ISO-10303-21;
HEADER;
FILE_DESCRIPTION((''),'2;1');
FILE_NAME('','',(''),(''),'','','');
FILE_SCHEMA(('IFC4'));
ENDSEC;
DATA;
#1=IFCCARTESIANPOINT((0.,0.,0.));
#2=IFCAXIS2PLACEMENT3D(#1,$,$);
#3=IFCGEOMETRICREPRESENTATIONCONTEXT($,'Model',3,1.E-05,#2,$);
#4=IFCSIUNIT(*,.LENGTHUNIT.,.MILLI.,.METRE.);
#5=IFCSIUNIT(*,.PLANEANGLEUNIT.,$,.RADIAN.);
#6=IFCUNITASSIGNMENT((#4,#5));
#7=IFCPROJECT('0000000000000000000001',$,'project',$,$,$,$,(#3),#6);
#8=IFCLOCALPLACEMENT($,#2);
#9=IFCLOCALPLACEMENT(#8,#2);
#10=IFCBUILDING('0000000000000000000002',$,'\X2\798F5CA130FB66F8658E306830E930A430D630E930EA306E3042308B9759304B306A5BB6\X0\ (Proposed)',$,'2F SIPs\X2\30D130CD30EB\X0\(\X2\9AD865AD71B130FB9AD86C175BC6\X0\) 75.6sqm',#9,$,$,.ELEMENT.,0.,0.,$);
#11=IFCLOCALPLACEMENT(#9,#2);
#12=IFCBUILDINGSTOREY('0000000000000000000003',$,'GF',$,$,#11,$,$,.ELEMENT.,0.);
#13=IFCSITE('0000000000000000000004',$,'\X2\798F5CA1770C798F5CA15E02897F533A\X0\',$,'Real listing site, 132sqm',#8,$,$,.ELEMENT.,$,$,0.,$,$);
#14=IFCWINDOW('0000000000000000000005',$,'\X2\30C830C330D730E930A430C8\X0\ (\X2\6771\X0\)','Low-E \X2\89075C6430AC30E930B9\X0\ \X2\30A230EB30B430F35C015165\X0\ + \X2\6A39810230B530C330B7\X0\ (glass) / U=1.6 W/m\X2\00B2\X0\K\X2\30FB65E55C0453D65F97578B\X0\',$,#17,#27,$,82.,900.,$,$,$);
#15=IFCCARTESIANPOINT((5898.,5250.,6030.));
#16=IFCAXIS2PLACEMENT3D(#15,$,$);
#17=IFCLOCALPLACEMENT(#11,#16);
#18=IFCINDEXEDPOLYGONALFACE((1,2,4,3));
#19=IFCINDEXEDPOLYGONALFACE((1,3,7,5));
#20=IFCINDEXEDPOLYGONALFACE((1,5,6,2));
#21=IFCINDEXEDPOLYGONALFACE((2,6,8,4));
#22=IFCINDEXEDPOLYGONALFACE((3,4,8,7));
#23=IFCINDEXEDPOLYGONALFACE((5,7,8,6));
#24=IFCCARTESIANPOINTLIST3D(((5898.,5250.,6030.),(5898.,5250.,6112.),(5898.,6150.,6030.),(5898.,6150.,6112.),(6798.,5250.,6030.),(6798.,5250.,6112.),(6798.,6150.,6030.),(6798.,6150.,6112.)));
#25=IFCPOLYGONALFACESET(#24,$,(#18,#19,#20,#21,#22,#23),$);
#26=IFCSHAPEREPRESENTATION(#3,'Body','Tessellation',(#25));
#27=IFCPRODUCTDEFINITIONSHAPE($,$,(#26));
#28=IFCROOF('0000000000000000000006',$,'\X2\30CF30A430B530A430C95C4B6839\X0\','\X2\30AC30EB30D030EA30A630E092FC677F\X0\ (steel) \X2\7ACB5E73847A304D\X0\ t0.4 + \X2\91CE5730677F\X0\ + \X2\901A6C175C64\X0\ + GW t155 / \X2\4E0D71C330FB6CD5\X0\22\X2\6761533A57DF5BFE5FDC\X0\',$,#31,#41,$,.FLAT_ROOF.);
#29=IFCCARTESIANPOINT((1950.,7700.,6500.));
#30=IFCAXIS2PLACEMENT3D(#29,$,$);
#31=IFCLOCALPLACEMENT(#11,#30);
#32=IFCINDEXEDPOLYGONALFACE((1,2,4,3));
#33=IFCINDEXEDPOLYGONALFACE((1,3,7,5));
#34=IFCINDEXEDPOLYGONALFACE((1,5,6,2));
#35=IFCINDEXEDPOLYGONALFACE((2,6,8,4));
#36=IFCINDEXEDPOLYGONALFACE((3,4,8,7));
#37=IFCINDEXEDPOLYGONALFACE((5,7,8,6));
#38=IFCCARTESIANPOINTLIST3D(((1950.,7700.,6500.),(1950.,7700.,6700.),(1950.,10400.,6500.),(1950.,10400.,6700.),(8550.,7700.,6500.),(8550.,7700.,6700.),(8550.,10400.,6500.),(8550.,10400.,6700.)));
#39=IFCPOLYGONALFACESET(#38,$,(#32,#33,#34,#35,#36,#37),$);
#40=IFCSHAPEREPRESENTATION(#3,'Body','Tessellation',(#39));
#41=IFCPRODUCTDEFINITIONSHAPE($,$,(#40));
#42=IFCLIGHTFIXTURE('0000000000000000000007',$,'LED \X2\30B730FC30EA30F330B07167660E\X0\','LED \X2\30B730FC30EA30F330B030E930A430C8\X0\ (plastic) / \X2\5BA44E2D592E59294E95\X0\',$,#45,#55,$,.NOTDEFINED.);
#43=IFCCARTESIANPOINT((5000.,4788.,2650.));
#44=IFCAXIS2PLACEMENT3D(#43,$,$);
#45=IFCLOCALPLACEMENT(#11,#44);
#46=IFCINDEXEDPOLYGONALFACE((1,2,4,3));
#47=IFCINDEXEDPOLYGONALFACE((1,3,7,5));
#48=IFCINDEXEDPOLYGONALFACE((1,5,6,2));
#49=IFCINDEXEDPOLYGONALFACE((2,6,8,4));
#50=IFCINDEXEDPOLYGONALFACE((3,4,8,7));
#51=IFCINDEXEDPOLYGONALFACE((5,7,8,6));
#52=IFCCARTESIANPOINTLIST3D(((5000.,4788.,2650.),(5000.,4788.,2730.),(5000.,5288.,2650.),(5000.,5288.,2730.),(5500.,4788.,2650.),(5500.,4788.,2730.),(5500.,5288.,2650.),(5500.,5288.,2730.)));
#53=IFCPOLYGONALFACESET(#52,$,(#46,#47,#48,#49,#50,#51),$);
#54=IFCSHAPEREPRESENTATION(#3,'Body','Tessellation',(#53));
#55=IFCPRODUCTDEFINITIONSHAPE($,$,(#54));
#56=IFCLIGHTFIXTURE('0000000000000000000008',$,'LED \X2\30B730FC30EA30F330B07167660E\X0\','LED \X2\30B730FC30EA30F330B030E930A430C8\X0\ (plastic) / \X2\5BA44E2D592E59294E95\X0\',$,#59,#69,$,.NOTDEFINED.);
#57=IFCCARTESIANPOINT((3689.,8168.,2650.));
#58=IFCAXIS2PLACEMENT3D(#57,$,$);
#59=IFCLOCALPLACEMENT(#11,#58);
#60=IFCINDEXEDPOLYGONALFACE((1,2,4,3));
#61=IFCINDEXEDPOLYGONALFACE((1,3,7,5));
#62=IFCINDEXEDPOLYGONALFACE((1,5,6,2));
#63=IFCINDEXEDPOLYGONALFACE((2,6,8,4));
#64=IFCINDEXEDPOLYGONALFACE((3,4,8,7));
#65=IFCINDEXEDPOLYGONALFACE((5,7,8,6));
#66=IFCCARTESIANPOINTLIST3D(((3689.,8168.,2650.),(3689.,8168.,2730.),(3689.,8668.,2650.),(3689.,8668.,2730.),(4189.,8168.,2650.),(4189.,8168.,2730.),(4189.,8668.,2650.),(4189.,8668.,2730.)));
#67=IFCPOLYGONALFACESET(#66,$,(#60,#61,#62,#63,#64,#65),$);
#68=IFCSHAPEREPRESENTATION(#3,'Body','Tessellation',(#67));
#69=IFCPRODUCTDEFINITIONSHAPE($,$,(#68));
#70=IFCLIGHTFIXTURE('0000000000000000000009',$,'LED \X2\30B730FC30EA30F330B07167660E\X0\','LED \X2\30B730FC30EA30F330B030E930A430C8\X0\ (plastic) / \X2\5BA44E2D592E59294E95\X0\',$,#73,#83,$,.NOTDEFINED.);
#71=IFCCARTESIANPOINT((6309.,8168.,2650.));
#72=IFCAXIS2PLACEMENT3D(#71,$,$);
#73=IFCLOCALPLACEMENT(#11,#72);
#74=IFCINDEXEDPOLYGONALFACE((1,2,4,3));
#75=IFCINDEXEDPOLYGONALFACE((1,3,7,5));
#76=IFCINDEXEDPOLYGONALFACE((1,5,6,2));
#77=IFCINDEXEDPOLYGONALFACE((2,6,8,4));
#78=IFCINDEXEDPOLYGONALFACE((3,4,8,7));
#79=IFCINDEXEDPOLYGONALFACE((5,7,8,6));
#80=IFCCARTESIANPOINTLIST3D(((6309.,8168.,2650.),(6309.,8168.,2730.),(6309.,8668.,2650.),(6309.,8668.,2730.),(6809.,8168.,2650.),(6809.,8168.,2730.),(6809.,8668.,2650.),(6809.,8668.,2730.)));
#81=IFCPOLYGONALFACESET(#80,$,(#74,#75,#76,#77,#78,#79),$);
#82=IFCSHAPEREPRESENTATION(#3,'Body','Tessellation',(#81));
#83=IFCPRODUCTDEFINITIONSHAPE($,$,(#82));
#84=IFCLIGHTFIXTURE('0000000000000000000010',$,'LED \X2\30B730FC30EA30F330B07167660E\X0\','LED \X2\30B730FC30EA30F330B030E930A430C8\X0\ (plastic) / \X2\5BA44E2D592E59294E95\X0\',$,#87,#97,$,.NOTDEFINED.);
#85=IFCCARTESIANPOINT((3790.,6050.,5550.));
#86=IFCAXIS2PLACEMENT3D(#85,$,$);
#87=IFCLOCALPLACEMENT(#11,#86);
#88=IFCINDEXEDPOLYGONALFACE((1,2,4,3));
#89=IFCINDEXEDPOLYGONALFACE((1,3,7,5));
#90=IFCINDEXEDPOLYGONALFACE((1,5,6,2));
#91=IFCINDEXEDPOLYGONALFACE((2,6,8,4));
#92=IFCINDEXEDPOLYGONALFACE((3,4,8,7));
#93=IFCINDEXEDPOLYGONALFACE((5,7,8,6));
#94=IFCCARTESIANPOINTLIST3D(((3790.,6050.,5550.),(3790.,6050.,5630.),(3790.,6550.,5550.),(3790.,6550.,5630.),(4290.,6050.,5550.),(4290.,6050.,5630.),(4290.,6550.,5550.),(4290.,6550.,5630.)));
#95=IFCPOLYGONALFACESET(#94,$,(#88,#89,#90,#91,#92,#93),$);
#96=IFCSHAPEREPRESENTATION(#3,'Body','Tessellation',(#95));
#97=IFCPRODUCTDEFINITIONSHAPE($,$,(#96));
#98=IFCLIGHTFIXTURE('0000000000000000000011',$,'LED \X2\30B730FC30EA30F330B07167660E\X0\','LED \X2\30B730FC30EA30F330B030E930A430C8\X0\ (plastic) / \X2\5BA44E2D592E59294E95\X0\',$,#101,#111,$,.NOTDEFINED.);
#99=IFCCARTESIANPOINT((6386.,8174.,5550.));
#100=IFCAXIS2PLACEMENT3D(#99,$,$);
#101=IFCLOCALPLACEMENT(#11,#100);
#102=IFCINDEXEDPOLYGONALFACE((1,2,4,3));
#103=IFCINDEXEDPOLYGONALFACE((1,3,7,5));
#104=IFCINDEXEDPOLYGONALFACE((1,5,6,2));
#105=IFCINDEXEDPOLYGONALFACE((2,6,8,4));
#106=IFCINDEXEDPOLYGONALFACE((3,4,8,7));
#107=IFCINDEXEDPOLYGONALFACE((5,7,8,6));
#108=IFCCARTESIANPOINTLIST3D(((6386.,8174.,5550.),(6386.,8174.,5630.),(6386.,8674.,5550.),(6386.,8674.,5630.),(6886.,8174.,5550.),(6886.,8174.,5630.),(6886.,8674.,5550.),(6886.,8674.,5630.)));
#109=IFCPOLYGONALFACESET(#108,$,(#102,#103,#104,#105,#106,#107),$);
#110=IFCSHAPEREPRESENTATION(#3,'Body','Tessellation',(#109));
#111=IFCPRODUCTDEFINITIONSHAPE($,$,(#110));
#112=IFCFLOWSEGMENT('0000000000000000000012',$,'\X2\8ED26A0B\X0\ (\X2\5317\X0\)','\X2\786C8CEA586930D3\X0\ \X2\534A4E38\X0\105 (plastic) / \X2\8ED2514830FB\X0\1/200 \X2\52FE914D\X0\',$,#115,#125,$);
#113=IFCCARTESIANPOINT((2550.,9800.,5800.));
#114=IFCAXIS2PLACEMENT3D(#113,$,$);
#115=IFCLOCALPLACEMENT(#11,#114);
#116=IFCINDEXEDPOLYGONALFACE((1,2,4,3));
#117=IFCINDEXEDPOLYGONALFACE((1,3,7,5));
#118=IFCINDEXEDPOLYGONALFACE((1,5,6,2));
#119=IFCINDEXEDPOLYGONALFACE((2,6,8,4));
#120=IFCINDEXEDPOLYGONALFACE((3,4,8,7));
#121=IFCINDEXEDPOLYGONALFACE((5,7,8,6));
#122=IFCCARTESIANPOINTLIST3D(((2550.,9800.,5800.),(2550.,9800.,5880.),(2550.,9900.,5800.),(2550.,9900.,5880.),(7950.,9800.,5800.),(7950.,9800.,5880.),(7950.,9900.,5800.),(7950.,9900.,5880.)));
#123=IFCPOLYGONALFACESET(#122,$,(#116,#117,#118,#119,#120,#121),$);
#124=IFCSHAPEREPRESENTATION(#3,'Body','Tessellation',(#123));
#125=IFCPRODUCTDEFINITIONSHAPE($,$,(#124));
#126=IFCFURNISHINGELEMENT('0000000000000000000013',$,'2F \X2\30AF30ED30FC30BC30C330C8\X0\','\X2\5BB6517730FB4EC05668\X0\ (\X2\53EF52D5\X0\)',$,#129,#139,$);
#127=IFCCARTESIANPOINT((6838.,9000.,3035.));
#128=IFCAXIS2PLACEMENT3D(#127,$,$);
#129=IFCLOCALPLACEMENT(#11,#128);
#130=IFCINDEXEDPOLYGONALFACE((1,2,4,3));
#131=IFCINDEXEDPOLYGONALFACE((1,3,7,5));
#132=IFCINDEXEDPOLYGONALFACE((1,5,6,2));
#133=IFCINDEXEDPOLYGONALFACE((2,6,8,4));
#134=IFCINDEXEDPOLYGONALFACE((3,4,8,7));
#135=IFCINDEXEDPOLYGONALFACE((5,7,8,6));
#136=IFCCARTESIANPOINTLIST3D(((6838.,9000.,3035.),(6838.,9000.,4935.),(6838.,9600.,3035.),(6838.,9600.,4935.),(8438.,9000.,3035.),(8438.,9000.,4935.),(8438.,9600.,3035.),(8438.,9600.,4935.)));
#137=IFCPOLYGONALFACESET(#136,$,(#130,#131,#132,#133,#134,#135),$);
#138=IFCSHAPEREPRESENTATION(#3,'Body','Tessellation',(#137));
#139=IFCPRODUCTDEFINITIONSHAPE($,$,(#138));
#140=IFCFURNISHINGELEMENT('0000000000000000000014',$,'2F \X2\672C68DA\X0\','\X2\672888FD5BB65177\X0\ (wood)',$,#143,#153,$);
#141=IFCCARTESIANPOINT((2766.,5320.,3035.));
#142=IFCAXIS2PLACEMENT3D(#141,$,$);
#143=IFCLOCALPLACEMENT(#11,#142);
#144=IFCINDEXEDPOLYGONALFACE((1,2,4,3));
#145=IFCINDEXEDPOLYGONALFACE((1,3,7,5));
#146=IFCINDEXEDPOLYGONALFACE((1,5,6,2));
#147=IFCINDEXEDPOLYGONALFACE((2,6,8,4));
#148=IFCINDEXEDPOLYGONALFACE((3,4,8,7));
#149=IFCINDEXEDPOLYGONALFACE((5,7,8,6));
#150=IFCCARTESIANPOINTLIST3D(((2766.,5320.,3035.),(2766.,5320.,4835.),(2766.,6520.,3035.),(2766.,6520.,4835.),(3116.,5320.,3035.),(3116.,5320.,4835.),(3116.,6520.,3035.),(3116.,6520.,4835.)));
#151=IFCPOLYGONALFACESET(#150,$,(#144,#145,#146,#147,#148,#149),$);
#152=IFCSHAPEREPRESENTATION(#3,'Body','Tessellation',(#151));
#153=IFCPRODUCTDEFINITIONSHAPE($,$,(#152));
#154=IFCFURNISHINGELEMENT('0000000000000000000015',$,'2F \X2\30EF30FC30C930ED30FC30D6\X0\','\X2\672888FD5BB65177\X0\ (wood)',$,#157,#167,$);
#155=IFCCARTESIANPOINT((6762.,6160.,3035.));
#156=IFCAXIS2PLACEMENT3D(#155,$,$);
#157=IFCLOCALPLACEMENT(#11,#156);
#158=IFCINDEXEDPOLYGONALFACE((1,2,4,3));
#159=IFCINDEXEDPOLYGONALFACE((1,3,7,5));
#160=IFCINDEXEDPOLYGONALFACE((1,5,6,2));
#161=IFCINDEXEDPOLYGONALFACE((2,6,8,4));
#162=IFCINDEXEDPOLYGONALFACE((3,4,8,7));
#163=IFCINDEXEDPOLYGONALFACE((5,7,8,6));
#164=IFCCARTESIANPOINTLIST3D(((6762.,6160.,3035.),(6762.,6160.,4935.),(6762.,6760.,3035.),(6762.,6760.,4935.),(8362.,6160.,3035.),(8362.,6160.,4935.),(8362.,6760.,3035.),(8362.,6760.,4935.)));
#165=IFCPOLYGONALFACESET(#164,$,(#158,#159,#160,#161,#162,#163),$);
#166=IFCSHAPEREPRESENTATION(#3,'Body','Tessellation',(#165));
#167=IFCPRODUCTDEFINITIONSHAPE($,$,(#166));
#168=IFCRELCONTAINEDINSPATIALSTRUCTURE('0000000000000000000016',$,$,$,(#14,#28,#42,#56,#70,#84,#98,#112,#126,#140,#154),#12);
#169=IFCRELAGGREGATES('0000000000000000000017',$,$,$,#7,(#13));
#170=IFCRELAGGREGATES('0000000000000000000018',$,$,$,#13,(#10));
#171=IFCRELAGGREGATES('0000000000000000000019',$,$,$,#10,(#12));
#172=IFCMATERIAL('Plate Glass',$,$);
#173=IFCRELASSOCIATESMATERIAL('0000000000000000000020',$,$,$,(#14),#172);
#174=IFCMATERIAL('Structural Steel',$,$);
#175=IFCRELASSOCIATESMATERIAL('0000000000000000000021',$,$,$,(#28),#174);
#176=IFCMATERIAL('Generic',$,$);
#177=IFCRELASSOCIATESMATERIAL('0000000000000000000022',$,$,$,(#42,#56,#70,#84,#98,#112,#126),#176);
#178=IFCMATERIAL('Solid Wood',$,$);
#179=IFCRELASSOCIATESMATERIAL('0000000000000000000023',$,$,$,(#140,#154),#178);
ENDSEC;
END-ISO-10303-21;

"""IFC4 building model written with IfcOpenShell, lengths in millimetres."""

from ifc_helpers import new_model, si_unit, frame, frame_2d, origin, place, context, project, spatial, rectangle, extrude, material, element, save


model = new_model("IFC4")

# Units and contexts
model_context = context("Model", 3, precision=1e-05, world=origin())
ifc_project = project(units=[si_unit("LENGTHUNIT", "METRE", prefix="MILLI"), si_unit("PLANEANGLEUNIT", "RADIAN")], contexts=[model_context])

# Site, building, storey
site_placement = place(None, origin())
site = spatial("IfcSite", under=ifc_project, at=site_placement, Name="福岡県福岡市西区", ObjectType="Real listing site, 132sqm", CompositionType="ELEMENT", RefElevation=0.0)
building_placement = place(site_placement, origin())
building = spatial("IfcBuilding", under=site, at=building_placement, Name="福岡・書斎とライブラリのある静かな家 (Proposed)", ObjectType="2F SIPsパネル(高断熱・高気密) 75.6sqm", CompositionType="ELEMENT", ElevationOfRefHeight=0.0, ElevationOfTerrain=0.0)
storey_placement = place(building_placement, origin())
storey = spatial("IfcBuildingStorey", under=building, at=storey_placement, Name="GF", CompositionType="ELEMENT", Elevation=0.0)

# Shared definitions
ifc_material_1 = material(Name="Solid Wood")

# Shared definitions
ifc_material_2 = material(Name="Plate Glass")

# Window
window_1_placement = place(storey_placement, frame((5898.0, 5250.0, 6030.0)))
element("IfcWindow", 1, at=window_1_placement, inside=storey, material=ifc_material_2, Name="トップライト (東)", Description="Low-E 複層ガラス アルゴン封入 + 樹脂サッシ (glass) / U=1.6 W/m²K・日射取得型", OverallHeight=82.0, OverallWidth=900.0, context=model_context, shape_type="SweptSolid", body=[
    extrude(rectangle(XDim=900.0, YDim=900.0, at=frame_2d((450.0, 450.0))), frame((5898.0, 5250.0, 6030.0)), (0.0, 0.0, 1.0), 82.0),
])

# Roof
ifc_material_3 = material(Name="Structural Steel")
roof_placement = place(storey_placement, frame((1950.0, 7700.0, 6500.0)))
element("IfcRoof", 2, at=roof_placement, inside=storey, material=ifc_material_3, Name="ハイサイド屋根", Description="ガルバリウム鋼板 (steel) 立平葺き t0.4 + 野地板 + 通気層 + GW t155 / 不燃・法22条区域対応", PredefinedType="FLAT_ROOF", context=model_context, shape_type="SweptSolid", body=[
    extrude(rectangle(XDim=6600.0, YDim=2700.0, at=frame_2d((3300.0, 1350.0))), frame((1950.0, 7700.0, 6500.0)), (0.0, 0.0, 1.0), 200.0),
])

# Light fixtures
ifc_material_4 = material(Name="Generic")
light_fixture_1_placement = place(storey_placement, frame((5000.0, 4788.0, 2650.0)))
element("IfcLightFixture", 3, at=light_fixture_1_placement, inside=storey, material=ifc_material_4, Name="LED シーリング照明", Description="LED シーリングライト (plastic) / 室中央天井", PredefinedType="NOTDEFINED", context=model_context, shape_type="SweptSolid", body=[
    extrude(rectangle(XDim=500.0, YDim=500.0, at=frame_2d((250.0, 250.0))), frame((5000.0, 4788.0, 2650.0)), (0.0, 0.0, 1.0), 80.0),
])
light_fixture_2_placement = place(storey_placement, frame((3689.0, 8168.0, 2650.0)))
element("IfcLightFixture", 4, at=light_fixture_2_placement, inside=storey, material=ifc_material_4, Name="LED シーリング照明", Description="LED シーリングライト (plastic) / 室中央天井", PredefinedType="NOTDEFINED", context=model_context, shape_type="SweptSolid", body=[
    extrude(rectangle(XDim=500.0, YDim=500.0, at=frame_2d((250.0, 250.0))), frame((3689.0, 8168.0, 2650.0)), (0.0, 0.0, 1.0), 80.0),
])
light_fixture_3_placement = place(storey_placement, frame((6309.0, 8168.0, 2650.0)))
element("IfcLightFixture", 5, at=light_fixture_3_placement, inside=storey, material=ifc_material_4, Name="LED シーリング照明", Description="LED シーリングライト (plastic) / 室中央天井", PredefinedType="NOTDEFINED", context=model_context, shape_type="SweptSolid", body=[
    extrude(rectangle(XDim=500.0, YDim=500.0, at=frame_2d((250.0, 250.0))), frame((6309.0, 8168.0, 2650.0)), (0.0, 0.0, 1.0), 80.0),
])
light_fixture_4_placement = place(storey_placement, frame((3790.0, 6050.0, 5550.0)))
element("IfcLightFixture", 6, at=light_fixture_4_placement, inside=storey, material=ifc_material_4, Name="LED シーリング照明", Description="LED シーリングライト (plastic) / 室中央天井", PredefinedType="NOTDEFINED", context=model_context, shape_type="SweptSolid", body=[
    extrude(rectangle(XDim=500.0, YDim=500.0, at=frame_2d((250.0, 250.0))), frame((3790.0, 6050.0, 5550.0)), (0.0, 0.0, 1.0), 80.0),
])
light_fixture_5_placement = place(storey_placement, frame((6386.0, 8174.0, 5550.0)))
element("IfcLightFixture", 7, at=light_fixture_5_placement, inside=storey, material=ifc_material_4, Name="LED シーリング照明", Description="LED シーリングライト (plastic) / 室中央天井", PredefinedType="NOTDEFINED", context=model_context, shape_type="SweptSolid", body=[
    extrude(rectangle(XDim=500.0, YDim=500.0, at=frame_2d((250.0, 250.0))), frame((6386.0, 8174.0, 5550.0)), (0.0, 0.0, 1.0), 80.0),
])

# Flow segment
flow_segment_placement = place(storey_placement, frame((2550.0, 9800.0, 5800.0)))
element("IfcFlowSegment", 8, at=flow_segment_placement, inside=storey, material=ifc_material_4, Name="軒樋 (北)", Description="硬質塩ビ 半丸105 (plastic) / 軒先・1/200 勾配", context=model_context, shape_type="SweptSolid", body=[
    extrude(rectangle(XDim=5400.0, YDim=100.0, at=frame_2d((2700.0, 50.0))), frame((2550.0, 9800.0, 5800.0)), (0.0, 0.0, 1.0), 80.0),
])

# Furnishing elements
furnishing_1_placement = place(storey_placement, frame((6838.0, 9000.0, 3035.0)))
element("IfcFurnishingElement", 9, at=furnishing_1_placement, inside=storey, material=ifc_material_4, Name="2F クローゼット", Description="家具・什器 (可動)", context=model_context, shape_type="SweptSolid", body=[
    extrude(rectangle(XDim=1600.0, YDim=600.0, at=frame_2d((800.0, 300.0))), frame((6838.0, 9000.0, 3035.0)), (0.0, 0.0, 1.0), 1900.0),
])
furnishing_2_placement = place(storey_placement, frame((2766.0, 5320.0, 3035.0)))
element("IfcFurnishingElement", 10, at=furnishing_2_placement, inside=storey, material=ifc_material_1, Name="2F 本棚", Description="木製家具 (wood)", context=model_context, shape_type="SweptSolid", body=[
    extrude(rectangle(XDim=350.0, YDim=1200.0, at=frame_2d((175.0, 600.0))), frame((2766.0, 5320.0, 3035.0)), (0.0, 0.0, 1.0), 1800.0),
])
furnishing_3_placement = place(storey_placement, frame((6762.0, 6160.0, 3035.0)))
element("IfcFurnishingElement", 11, at=furnishing_3_placement, inside=storey, material=ifc_material_1, Name="2F ワードローブ", Description="木製家具 (wood)", context=model_context, shape_type="SweptSolid", body=[
    extrude(rectangle(XDim=1600.0, YDim=600.0, at=frame_2d((800.0, 300.0))), frame((6762.0, 6160.0, 3035.0)), (0.0, 0.0, 1.0), 1900.0),
])

save(model, "model.ifc")
